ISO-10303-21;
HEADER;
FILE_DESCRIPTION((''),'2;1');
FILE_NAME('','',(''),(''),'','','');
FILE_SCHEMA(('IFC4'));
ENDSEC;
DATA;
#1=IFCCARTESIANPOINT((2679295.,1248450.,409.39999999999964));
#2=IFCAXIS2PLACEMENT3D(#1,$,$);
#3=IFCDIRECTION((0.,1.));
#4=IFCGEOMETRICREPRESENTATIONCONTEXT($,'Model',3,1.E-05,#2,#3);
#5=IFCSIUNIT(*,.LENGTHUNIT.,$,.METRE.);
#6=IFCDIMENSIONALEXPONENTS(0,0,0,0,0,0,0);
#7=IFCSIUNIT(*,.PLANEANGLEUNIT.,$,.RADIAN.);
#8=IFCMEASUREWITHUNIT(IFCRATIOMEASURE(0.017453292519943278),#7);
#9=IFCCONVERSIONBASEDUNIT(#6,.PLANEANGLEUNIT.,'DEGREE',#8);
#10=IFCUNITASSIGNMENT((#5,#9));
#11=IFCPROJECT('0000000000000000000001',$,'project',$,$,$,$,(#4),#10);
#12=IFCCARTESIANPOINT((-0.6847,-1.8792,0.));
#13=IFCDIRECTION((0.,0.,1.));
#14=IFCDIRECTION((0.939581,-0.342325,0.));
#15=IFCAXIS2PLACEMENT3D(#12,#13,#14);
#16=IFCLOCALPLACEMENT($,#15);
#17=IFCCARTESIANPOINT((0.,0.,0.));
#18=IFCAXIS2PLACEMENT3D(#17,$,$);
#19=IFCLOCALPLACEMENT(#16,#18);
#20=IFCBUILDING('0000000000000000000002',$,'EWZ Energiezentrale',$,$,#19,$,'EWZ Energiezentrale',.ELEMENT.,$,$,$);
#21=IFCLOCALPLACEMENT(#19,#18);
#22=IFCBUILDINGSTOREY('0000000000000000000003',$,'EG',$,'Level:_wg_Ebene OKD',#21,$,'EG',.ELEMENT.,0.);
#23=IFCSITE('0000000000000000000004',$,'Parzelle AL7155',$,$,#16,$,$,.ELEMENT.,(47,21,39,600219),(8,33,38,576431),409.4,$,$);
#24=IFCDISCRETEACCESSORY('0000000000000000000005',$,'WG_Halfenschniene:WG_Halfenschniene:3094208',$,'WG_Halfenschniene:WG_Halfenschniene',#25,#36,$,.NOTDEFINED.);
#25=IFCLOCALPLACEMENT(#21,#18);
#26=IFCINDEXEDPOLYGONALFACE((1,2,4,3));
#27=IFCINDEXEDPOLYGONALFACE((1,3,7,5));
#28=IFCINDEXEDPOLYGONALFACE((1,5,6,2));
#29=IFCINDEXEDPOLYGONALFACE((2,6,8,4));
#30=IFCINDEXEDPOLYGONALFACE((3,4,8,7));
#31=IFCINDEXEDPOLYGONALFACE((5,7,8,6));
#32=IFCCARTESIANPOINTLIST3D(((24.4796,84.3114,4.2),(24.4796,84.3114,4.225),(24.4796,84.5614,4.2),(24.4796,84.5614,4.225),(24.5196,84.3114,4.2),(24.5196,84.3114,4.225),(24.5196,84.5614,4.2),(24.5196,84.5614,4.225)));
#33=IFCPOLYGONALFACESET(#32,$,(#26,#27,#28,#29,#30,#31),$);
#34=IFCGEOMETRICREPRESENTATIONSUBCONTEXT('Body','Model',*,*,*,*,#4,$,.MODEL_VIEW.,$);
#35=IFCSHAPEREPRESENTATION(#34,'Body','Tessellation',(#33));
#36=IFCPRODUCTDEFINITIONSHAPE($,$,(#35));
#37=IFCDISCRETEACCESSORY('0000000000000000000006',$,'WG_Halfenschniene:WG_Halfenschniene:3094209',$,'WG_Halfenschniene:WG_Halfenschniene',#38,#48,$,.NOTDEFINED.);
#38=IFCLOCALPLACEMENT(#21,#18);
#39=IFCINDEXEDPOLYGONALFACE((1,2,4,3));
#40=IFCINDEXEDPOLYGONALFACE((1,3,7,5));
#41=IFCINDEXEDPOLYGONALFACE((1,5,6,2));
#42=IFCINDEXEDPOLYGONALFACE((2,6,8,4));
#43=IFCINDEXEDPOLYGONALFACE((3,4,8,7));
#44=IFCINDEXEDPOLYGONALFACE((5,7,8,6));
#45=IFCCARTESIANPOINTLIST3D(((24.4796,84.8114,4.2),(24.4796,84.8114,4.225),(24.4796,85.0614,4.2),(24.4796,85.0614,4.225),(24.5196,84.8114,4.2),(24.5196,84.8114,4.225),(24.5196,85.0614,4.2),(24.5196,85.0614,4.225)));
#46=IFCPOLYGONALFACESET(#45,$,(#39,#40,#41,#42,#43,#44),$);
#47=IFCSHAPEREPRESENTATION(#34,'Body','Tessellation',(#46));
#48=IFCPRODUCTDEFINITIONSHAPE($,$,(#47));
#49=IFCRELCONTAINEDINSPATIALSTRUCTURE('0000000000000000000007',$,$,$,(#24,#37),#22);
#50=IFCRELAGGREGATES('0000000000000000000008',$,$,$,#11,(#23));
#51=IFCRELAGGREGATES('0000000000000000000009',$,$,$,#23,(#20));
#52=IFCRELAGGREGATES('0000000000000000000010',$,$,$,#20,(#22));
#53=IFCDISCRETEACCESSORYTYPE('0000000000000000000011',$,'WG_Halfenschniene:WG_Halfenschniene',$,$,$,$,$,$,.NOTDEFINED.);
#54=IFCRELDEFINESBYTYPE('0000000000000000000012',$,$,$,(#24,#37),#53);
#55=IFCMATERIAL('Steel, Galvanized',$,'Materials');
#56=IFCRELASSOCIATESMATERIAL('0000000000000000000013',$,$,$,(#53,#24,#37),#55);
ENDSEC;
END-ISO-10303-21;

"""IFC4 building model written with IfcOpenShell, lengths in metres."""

from ifc_helpers import new_model, entity, si_unit, converted_unit, direction, frame, origin, place, context, subcontext, project, spatial, indexed_curve, outline, extrude, source, transform, mapped, material, type_object, element, save


model = new_model("IFC4")

# Units and contexts
model_context = context("Model", 3, precision=1e-05, world=frame((2679295.0, 1248450.0, 409.39999999999964)), true_north=direction((0.0, 1.0)))
body_context = subcontext(model_context, "Body", "Model", "MODEL_VIEW")
ifc_project = project(units=[si_unit("LENGTHUNIT", "METRE"), converted_unit("PLANEANGLEUNIT", "DEGREE", entity("IfcRatioMeasure", 0.017453292519943278), si_unit("PLANEANGLEUNIT", "RADIAN"), dimensions=[0, 0, 0, 0, 0, 0, 0])], contexts=[model_context])

# Site, building, storey
site_placement = place(None, frame((-0.6847, -1.8792, 0.0), z_axis=(0.0, 0.0, 1.0), x_axis=(0.939581, -0.342325, 0.0)))
site = spatial("IfcSite", under=ifc_project, at=site_placement, Name="Parzelle AL7155", CompositionType="ELEMENT", RefLatitude=(47, 21, 39, 600219), RefLongitude=(8, 33, 38, 576431), RefElevation=409.4)
building_placement = place(site_placement, origin())
building = spatial("IfcBuilding", under=site, at=building_placement, Name="EWZ Energiezentrale", LongName="EWZ Energiezentrale", CompositionType="ELEMENT")
storey_placement = place(building_placement, origin())
storey = spatial("IfcBuildingStorey", under=building, at=storey_placement, Name="EG", ObjectType="Level:_wg_Ebene OKD", LongName="EG", CompositionType="ELEMENT", Elevation=0.0)

# Discrete accessories
ifc_material = material(Name="Steel, Galvanized", Category="Materials")
discrete_accessory_type = type_object("IfcDiscreteAccessoryType", Name="WG_Halfenschniene:WG_Halfenschniene", PredefinedType="NOTDEFINED", material=ifc_material)
shared_shape = source(origin(), body_context, "Body", "SweptSolid", [
    extrude(outline(indexed_curve([(-0.125, -0.02), (0.125, -0.02), (0.125, 0.02), (-0.125, 0.02), (-0.125, -0.02)], self_intersect=False)), frame((0.125, 0.0, -0.0125)), (0.0, 0.0, 1.0), 0.025),
])
for number, where, z_axis, x_axis, name in (
    (1, (24.4996, 84.3114, 4.2125), (0.0, 0.0, -1.0), (0.0, 1.0, 0.0), "WG_Halfenschniene:WG_Halfenschniene:3094208"),
    (2, (24.4996, 84.8114, 4.2125), (0.0, 0.0, -1.0), (0.0, 1.0, 0.0), "WG_Halfenschniene:WG_Halfenschniene:3094209"),
):
    element("IfcDiscreteAccessory", number, at=place(storey_placement, frame(where, z_axis=z_axis, x_axis=x_axis)), inside=storey, type_object=discrete_accessory_type, material=ifc_material, Name=name, ObjectType="WG_Halfenschniene:WG_Halfenschniene", PredefinedType="NOTDEFINED", context=body_context, shape_type="MappedRepresentation", body=[
        mapped(shared_shape, transform((0.0, 0.0, 0.0), scale=1.0)),
    ])

save(model, "model.ifc")
